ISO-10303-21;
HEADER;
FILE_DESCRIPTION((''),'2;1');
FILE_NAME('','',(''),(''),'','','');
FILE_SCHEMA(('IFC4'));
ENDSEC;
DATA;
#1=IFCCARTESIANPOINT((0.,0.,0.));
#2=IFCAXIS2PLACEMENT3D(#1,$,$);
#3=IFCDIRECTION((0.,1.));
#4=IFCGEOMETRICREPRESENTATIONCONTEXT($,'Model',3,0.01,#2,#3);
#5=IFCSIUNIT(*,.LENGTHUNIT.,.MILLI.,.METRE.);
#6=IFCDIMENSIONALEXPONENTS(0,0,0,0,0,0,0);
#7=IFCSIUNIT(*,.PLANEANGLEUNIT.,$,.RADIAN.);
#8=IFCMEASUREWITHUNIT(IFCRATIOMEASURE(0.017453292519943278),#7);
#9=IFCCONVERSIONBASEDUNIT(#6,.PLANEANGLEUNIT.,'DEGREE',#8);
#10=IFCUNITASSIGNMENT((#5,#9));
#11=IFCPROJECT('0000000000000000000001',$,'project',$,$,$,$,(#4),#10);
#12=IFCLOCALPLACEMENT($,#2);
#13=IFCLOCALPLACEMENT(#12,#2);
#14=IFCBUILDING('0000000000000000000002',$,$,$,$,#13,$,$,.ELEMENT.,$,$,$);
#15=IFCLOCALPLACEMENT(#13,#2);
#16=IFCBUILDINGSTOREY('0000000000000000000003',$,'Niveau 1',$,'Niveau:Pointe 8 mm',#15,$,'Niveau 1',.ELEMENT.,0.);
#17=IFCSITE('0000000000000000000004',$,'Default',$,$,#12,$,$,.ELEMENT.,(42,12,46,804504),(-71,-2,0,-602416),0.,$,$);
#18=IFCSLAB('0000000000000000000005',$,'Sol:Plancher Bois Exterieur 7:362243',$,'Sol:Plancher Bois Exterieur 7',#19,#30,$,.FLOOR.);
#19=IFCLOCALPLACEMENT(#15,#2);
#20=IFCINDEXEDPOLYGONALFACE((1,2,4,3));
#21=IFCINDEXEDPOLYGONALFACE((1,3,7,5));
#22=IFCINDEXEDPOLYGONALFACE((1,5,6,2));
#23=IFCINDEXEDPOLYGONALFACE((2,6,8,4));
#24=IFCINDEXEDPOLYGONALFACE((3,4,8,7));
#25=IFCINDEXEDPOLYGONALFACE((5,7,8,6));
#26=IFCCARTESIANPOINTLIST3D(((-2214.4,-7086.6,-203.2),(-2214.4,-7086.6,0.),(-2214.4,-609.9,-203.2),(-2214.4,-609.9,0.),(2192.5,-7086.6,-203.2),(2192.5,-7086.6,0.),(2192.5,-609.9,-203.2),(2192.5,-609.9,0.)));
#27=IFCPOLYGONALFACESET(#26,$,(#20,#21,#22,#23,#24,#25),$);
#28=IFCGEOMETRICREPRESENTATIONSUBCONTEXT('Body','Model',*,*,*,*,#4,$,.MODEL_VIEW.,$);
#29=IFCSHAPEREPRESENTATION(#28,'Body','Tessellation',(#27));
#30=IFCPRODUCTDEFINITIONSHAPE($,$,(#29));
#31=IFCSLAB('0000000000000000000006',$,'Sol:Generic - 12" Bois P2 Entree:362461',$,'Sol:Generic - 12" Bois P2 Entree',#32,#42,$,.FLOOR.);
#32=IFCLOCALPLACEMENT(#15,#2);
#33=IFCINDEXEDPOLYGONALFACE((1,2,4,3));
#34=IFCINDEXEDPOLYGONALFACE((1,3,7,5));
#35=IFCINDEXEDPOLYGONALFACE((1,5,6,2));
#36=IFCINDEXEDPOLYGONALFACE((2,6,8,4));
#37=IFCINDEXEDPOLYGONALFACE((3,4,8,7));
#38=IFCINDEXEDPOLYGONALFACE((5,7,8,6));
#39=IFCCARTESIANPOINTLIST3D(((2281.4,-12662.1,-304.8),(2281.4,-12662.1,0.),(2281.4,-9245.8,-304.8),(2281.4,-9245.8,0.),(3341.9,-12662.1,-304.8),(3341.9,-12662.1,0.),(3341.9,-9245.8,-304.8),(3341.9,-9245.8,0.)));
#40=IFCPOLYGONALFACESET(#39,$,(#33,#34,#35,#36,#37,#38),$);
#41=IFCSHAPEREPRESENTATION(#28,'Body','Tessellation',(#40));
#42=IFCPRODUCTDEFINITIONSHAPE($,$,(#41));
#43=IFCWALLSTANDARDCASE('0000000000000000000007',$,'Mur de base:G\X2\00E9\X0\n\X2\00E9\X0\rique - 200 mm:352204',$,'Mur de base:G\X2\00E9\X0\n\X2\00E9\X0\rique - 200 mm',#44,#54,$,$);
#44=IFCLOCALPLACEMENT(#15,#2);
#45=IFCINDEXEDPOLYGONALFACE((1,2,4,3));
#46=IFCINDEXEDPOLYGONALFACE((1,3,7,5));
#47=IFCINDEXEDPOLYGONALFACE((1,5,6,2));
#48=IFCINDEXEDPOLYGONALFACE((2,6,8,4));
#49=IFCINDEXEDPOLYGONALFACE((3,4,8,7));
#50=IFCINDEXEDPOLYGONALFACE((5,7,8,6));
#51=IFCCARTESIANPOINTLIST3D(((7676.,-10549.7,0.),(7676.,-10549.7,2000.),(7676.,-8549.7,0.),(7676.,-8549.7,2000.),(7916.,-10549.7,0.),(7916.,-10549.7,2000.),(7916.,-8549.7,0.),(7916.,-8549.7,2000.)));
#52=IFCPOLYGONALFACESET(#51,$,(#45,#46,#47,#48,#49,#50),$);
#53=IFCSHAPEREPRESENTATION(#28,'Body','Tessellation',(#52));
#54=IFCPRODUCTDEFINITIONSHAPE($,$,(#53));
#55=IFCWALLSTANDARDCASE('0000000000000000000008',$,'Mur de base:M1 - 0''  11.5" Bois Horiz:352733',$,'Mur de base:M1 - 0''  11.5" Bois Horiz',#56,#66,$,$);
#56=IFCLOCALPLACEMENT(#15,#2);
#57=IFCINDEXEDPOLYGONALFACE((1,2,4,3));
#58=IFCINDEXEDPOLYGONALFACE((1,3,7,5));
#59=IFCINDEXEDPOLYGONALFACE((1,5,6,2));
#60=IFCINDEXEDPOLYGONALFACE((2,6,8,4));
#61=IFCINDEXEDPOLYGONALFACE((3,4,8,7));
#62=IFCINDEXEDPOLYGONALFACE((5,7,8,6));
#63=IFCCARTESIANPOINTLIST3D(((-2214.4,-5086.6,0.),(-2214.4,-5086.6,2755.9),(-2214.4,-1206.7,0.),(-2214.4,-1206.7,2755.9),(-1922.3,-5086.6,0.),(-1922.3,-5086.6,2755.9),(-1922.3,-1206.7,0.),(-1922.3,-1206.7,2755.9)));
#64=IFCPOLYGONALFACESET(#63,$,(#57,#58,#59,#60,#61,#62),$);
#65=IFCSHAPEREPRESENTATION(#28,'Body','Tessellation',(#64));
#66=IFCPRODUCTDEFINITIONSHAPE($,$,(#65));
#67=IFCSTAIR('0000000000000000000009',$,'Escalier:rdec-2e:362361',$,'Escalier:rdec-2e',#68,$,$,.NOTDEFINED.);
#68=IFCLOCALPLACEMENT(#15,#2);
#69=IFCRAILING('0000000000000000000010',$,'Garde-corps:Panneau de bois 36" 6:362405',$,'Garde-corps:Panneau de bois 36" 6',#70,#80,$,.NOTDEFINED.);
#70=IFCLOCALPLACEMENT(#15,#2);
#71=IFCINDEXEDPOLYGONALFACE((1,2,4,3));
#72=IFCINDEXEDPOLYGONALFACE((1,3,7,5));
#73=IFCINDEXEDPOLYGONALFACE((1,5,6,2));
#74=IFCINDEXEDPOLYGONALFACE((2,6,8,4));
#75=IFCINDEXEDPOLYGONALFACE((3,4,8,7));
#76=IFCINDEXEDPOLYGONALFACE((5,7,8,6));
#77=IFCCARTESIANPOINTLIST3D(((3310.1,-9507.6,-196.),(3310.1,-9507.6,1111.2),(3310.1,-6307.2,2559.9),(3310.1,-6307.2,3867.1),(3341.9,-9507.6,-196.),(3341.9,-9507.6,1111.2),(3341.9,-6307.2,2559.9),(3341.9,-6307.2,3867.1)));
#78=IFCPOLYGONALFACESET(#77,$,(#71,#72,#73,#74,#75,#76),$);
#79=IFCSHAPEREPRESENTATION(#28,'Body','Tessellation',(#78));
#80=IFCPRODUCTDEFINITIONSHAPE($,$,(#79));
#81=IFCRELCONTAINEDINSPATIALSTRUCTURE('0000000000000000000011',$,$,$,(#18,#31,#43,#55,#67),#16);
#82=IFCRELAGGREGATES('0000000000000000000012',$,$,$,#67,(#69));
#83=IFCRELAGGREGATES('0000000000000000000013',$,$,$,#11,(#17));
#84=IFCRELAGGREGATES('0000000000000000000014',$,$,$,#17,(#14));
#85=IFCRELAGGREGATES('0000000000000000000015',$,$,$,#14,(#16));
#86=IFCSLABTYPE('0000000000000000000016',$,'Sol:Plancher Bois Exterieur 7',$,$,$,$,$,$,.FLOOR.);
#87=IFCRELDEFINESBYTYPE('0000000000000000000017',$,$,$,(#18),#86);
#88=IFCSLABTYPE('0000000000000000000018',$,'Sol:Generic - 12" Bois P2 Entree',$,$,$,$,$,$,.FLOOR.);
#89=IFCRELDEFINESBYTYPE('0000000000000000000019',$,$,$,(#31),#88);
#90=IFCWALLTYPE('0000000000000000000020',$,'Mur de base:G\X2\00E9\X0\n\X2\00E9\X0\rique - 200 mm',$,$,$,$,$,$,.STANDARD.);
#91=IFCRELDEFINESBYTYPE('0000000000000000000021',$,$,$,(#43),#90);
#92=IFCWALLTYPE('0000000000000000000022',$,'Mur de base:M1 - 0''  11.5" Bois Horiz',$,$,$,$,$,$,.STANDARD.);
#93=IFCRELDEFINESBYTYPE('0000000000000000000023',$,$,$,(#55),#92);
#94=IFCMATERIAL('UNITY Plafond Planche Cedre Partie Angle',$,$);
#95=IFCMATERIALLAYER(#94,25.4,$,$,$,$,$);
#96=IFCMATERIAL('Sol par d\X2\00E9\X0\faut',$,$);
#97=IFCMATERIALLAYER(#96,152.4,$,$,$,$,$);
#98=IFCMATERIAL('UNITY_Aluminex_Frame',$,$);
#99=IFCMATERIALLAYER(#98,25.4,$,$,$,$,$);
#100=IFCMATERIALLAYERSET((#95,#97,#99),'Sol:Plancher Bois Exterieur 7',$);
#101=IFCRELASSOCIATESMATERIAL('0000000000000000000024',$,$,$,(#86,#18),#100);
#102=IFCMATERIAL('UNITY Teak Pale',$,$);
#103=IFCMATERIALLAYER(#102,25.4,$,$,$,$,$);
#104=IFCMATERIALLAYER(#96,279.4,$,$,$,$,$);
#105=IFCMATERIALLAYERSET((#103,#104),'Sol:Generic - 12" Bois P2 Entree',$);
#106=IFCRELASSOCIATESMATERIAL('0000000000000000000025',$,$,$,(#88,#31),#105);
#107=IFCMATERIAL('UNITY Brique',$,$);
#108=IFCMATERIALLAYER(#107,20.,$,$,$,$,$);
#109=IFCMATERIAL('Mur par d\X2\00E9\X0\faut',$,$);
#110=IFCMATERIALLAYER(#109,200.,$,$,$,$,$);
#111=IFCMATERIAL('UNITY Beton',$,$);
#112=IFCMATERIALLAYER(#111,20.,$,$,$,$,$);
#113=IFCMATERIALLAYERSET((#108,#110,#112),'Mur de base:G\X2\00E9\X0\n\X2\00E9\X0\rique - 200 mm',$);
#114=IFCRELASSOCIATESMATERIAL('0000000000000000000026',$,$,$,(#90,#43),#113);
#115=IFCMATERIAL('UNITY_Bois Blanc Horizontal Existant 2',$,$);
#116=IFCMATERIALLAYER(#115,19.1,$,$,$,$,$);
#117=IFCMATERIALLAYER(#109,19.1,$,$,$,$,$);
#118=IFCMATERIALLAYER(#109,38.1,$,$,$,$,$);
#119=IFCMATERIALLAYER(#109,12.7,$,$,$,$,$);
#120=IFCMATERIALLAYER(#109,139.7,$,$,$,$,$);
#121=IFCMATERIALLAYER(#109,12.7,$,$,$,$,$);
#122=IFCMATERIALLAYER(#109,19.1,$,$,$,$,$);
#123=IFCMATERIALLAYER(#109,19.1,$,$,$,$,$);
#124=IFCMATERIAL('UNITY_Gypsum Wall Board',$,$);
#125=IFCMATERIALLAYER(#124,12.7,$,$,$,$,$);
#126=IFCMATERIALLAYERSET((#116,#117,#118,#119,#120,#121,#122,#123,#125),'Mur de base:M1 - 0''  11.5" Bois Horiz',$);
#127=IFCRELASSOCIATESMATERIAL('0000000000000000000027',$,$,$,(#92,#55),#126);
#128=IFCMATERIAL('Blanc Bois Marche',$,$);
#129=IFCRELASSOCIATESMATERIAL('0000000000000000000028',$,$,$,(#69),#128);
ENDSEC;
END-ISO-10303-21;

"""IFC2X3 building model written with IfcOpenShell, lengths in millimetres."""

from ifc_helpers import new_model, entity, si_unit, converted_unit, direction, frame, frame_2d, origin, place, context, subcontext, project, spatial, polyline, rectangle, outline, extrude, material, layer, layer_set, layer_usage, type_object, element, aggregate, save


model = new_model("IFC2X3")

# Units and contexts
model_context = context("Model", 3, precision=0.01, world=origin(), true_north=direction((0.0, 1.0)))
body_context = subcontext(model_context, "Body", "Model", "MODEL_VIEW")
ifc_project = project(units=[si_unit("LENGTHUNIT", "METRE", prefix="MILLI"), converted_unit("PLANEANGLEUNIT", "DEGREE", entity("IfcRatioMeasure", 0.017453292519943278), si_unit("PLANEANGLEUNIT", "RADIAN"), dimensions=[0, 0, 0, 0, 0, 0, 0])], contexts=[model_context])

# Site, building, storey
site_placement = place(None, origin())
site = spatial("IfcSite", under=ifc_project, at=site_placement, Name="Default", CompositionType="ELEMENT", RefLatitude=(42, 12, 46, 804504), RefLongitude=(-71, -2, 0, -602416), RefElevation=0.0)
building_placement = place(site_placement, origin())
building = spatial("IfcBuilding", under=site, at=building_placement, CompositionType="ELEMENT")
storey_placement = place(building_placement, origin())
storey = spatial("IfcBuildingStorey", under=building, at=storey_placement, Name="Niveau 1", ObjectType="Niveau:Pointe 8 mm", LongName="Niveau 1", CompositionType="ELEMENT", Elevation=0.0)

# Slabs
ifc_material_1 = material(Name="UNITY Plafond Planche Cedre Partie Angle")
ifc_layer_1 = layer(ifc_material_1, 25.4)
ifc_material_2 = material(Name="Sol par défaut")
ifc_layer_2 = layer(ifc_material_2, 152.4)
ifc_material_3 = material(Name="UNITY_Aluminex_Frame")
ifc_layer_3 = layer(ifc_material_3, 25.4)
ifc_layer_set_1 = layer_set([ifc_layer_1, ifc_layer_2, ifc_layer_3], Name="Sol:Plancher Bois Exterieur 7")
ifc_layer_usage_1 = layer_usage(ifc_layer_set_1, "AXIS3", "POSITIVE", 0.0)
slab_type_1 = type_object("IfcSlabType", Name="Sol:Plancher Bois Exterieur 7", PredefinedType="FLOOR", material=ifc_layer_set_1)
slab_1_placement = place(storey_placement, origin())
element("IfcSlab", 1, at=slab_1_placement, inside=storey, type_object=slab_type_1, material=ifc_layer_usage_1, Name="Sol:Plancher Bois Exterieur 7:362243", ObjectType="Sol:Plancher Bois Exterieur 7", PredefinedType="FLOOR", context=body_context, shape_type="SweptSolid", body=[
    extrude(rectangle(XDim=6476.6, YDim=4406.9, at=frame_2d((0.0, 0.0), x_axis=(1.0, 0.0))), frame((-10.9, -3848.2, 0.0), z_axis=(0.0, 0.0, -1.0), x_axis=(0.0, 1.0, 0.0)), (0.0, 0.0, 1.0), 203.2),
])
ifc_material_4 = material(Name="UNITY Teak Pale")
ifc_layer_4 = layer(ifc_material_4, 25.4)
ifc_layer_5 = layer(ifc_material_2, 279.4)
ifc_layer_set_2 = layer_set([ifc_layer_4, ifc_layer_5], Name="Sol:Generic - 12\" Bois P2 Entree")
ifc_layer_usage_2 = layer_usage(ifc_layer_set_2, "AXIS3", "POSITIVE", 0.0)
slab_type_2 = type_object("IfcSlabType", Name="Sol:Generic - 12\" Bois P2 Entree", PredefinedType="FLOOR", material=ifc_layer_set_2)
slab_2_placement = place(storey_placement, origin())
element("IfcSlab", 2, at=slab_2_placement, inside=storey, type_object=slab_type_2, material=ifc_layer_usage_2, Name="Sol:Generic - 12\" Bois P2 Entree:362461", ObjectType="Sol:Generic - 12\" Bois P2 Entree", PredefinedType="FLOOR", context=body_context, shape_type="SweptSolid", body=[
    extrude(rectangle(XDim=3416.3, YDim=1060.5, at=frame_2d((0.0, 0.0), x_axis=(1.0, 0.0))), frame((2811.6, -10954.0, 0.0), z_axis=(0.0, 0.0, -1.0), x_axis=(0.0, 1.0, 0.0)), (0.0, 0.0, 1.0), 304.8),
])

# Wall
ifc_material_5 = material(Name="UNITY Brique")
ifc_layer_6 = layer(ifc_material_5, 20.0)
ifc_material_6 = material(Name="Mur par défaut")
ifc_layer_7 = layer(ifc_material_6, 200.0)
ifc_material_7 = material(Name="UNITY Beton")
ifc_layer_8 = layer(ifc_material_7, 20.0)
ifc_layer_set_3 = layer_set([ifc_layer_6, ifc_layer_7, ifc_layer_8], Name="Mur de base:Générique - 200 mm")
ifc_layer_usage_3 = layer_usage(ifc_layer_set_3, "AXIS2", "NEGATIVE", 120.0)
wall_type_1 = type_object("IfcWallType", Name="Mur de base:Générique - 200 mm", PredefinedType="STANDARD", material=ifc_layer_set_3)
wall_1_placement = place(storey_placement, frame((7796.0, -8549.7, 0.0), z_axis=(0.0, 0.0, 1.0), x_axis=(0.0, -1.0, 0.0)))
element("IfcWallStandardCase", 3, at=wall_1_placement, inside=storey, type_object=wall_type_1, material=ifc_layer_usage_3, Name="Mur de base:Générique - 200 mm:352204", ObjectType="Mur de base:Générique - 200 mm", context=body_context, shape_type="SweptSolid", body=[
    extrude(rectangle(XDim=2000.0, YDim=240.0, at=frame_2d((1000.0, 0.0), x_axis=(-1.0, 0.0))), origin(), (0.0, 0.0, 1.0), 2000.0),
])

# Shared definitions
ifc_material_8 = material(Name="UNITY_Bois Blanc Horizontal Existant 2")
ifc_layer_9 = layer(ifc_material_8, 19.1)
ifc_layer_10 = layer(ifc_material_6, 19.1)
ifc_layer_11 = layer(ifc_material_6, 38.1)
ifc_layer_12 = layer(ifc_material_6, 12.7)
ifc_layer_13 = layer(ifc_material_6, 139.7)
ifc_layer_14 = layer(ifc_material_6, 12.7)
ifc_layer_15 = layer(ifc_material_6, 19.1)
ifc_layer_16 = layer(ifc_material_6, 19.1)
ifc_material_9 = material(Name="UNITY_Gypsum Wall Board")
ifc_layer_17 = layer(ifc_material_9, 12.7)
ifc_layer_set_4 = layer_set([ifc_layer_9, ifc_layer_10, ifc_layer_11, ifc_layer_12, ifc_layer_13, ifc_layer_14, ifc_layer_15, ifc_layer_16, ifc_layer_17], Name="Mur de base:M1 - 0'  11.5\" Bois Horiz")
wall_type_2 = type_object("IfcWallType", Name="Mur de base:M1 - 0'  11.5\" Bois Horiz", PredefinedType="STANDARD", material=ifc_layer_set_4)

# Wall
ifc_layer_usage_4 = layer_usage(ifc_layer_set_4, "AXIS2", "NEGATIVE", 146.1)
wall_2_placement = place(storey_placement, frame((-2068.3, -5086.6, 0.0), z_axis=(0.0, 0.0, 1.0), x_axis=(0.0, 1.0, 0.0)))
element("IfcWallStandardCase", 4, at=wall_2_placement, inside=storey, type_object=wall_type_2, material=ifc_layer_usage_4, Name="Mur de base:M1 - 0'  11.5\" Bois Horiz:352733", ObjectType="Mur de base:M1 - 0'  11.5\" Bois Horiz", context=body_context, shape_type="SweptSolid", body=[
    extrude(rectangle(XDim=3879.8, YDim=292.1, at=frame_2d((1939.9, 0.0), x_axis=(-1.0, 0.0))), origin(), (0.0, 0.0, 1.0), 2755.9),
])

# Stair, railing
stair_1_placement = place(storey_placement, origin())
stair_1 = element("IfcStair", 5, at=stair_1_placement, inside=storey, Name="Escalier:rdec-2e:362361", ObjectType="Escalier:rdec-2e", ShapeType="NOTDEFINED")
ifc_material_10 = material(Name="Blanc Bois Marche")
railing_placement = place(stair_1_placement, frame((0.0, 0.0, 4000.0)))
railing = element("IfcRailing", 6, at=railing_placement, material=ifc_material_10, Name="Garde-corps:Panneau de bois 36\" 6:362405", ObjectType="Garde-corps:Panneau de bois 36\" 6", PredefinedType="NOTDEFINED", context=body_context, shape_type="SweptSolid", body=[
    extrude(outline(polyline([(-2538.2, -495.3), (1685.2, -495.3), (2538.2, 495.3), (-1685.2, 495.3), (-2538.2, -495.3)])), frame((3310.1, -7907.4, -2164.4), z_axis=(1.0, 0.0, 0.0), x_axis=(0.0, -0.757769, -0.652523)), (0.0, 0.0, 1.0), 31.8),
])
aggregate(stair_1, [railing])

save(model, "model.ifc")
